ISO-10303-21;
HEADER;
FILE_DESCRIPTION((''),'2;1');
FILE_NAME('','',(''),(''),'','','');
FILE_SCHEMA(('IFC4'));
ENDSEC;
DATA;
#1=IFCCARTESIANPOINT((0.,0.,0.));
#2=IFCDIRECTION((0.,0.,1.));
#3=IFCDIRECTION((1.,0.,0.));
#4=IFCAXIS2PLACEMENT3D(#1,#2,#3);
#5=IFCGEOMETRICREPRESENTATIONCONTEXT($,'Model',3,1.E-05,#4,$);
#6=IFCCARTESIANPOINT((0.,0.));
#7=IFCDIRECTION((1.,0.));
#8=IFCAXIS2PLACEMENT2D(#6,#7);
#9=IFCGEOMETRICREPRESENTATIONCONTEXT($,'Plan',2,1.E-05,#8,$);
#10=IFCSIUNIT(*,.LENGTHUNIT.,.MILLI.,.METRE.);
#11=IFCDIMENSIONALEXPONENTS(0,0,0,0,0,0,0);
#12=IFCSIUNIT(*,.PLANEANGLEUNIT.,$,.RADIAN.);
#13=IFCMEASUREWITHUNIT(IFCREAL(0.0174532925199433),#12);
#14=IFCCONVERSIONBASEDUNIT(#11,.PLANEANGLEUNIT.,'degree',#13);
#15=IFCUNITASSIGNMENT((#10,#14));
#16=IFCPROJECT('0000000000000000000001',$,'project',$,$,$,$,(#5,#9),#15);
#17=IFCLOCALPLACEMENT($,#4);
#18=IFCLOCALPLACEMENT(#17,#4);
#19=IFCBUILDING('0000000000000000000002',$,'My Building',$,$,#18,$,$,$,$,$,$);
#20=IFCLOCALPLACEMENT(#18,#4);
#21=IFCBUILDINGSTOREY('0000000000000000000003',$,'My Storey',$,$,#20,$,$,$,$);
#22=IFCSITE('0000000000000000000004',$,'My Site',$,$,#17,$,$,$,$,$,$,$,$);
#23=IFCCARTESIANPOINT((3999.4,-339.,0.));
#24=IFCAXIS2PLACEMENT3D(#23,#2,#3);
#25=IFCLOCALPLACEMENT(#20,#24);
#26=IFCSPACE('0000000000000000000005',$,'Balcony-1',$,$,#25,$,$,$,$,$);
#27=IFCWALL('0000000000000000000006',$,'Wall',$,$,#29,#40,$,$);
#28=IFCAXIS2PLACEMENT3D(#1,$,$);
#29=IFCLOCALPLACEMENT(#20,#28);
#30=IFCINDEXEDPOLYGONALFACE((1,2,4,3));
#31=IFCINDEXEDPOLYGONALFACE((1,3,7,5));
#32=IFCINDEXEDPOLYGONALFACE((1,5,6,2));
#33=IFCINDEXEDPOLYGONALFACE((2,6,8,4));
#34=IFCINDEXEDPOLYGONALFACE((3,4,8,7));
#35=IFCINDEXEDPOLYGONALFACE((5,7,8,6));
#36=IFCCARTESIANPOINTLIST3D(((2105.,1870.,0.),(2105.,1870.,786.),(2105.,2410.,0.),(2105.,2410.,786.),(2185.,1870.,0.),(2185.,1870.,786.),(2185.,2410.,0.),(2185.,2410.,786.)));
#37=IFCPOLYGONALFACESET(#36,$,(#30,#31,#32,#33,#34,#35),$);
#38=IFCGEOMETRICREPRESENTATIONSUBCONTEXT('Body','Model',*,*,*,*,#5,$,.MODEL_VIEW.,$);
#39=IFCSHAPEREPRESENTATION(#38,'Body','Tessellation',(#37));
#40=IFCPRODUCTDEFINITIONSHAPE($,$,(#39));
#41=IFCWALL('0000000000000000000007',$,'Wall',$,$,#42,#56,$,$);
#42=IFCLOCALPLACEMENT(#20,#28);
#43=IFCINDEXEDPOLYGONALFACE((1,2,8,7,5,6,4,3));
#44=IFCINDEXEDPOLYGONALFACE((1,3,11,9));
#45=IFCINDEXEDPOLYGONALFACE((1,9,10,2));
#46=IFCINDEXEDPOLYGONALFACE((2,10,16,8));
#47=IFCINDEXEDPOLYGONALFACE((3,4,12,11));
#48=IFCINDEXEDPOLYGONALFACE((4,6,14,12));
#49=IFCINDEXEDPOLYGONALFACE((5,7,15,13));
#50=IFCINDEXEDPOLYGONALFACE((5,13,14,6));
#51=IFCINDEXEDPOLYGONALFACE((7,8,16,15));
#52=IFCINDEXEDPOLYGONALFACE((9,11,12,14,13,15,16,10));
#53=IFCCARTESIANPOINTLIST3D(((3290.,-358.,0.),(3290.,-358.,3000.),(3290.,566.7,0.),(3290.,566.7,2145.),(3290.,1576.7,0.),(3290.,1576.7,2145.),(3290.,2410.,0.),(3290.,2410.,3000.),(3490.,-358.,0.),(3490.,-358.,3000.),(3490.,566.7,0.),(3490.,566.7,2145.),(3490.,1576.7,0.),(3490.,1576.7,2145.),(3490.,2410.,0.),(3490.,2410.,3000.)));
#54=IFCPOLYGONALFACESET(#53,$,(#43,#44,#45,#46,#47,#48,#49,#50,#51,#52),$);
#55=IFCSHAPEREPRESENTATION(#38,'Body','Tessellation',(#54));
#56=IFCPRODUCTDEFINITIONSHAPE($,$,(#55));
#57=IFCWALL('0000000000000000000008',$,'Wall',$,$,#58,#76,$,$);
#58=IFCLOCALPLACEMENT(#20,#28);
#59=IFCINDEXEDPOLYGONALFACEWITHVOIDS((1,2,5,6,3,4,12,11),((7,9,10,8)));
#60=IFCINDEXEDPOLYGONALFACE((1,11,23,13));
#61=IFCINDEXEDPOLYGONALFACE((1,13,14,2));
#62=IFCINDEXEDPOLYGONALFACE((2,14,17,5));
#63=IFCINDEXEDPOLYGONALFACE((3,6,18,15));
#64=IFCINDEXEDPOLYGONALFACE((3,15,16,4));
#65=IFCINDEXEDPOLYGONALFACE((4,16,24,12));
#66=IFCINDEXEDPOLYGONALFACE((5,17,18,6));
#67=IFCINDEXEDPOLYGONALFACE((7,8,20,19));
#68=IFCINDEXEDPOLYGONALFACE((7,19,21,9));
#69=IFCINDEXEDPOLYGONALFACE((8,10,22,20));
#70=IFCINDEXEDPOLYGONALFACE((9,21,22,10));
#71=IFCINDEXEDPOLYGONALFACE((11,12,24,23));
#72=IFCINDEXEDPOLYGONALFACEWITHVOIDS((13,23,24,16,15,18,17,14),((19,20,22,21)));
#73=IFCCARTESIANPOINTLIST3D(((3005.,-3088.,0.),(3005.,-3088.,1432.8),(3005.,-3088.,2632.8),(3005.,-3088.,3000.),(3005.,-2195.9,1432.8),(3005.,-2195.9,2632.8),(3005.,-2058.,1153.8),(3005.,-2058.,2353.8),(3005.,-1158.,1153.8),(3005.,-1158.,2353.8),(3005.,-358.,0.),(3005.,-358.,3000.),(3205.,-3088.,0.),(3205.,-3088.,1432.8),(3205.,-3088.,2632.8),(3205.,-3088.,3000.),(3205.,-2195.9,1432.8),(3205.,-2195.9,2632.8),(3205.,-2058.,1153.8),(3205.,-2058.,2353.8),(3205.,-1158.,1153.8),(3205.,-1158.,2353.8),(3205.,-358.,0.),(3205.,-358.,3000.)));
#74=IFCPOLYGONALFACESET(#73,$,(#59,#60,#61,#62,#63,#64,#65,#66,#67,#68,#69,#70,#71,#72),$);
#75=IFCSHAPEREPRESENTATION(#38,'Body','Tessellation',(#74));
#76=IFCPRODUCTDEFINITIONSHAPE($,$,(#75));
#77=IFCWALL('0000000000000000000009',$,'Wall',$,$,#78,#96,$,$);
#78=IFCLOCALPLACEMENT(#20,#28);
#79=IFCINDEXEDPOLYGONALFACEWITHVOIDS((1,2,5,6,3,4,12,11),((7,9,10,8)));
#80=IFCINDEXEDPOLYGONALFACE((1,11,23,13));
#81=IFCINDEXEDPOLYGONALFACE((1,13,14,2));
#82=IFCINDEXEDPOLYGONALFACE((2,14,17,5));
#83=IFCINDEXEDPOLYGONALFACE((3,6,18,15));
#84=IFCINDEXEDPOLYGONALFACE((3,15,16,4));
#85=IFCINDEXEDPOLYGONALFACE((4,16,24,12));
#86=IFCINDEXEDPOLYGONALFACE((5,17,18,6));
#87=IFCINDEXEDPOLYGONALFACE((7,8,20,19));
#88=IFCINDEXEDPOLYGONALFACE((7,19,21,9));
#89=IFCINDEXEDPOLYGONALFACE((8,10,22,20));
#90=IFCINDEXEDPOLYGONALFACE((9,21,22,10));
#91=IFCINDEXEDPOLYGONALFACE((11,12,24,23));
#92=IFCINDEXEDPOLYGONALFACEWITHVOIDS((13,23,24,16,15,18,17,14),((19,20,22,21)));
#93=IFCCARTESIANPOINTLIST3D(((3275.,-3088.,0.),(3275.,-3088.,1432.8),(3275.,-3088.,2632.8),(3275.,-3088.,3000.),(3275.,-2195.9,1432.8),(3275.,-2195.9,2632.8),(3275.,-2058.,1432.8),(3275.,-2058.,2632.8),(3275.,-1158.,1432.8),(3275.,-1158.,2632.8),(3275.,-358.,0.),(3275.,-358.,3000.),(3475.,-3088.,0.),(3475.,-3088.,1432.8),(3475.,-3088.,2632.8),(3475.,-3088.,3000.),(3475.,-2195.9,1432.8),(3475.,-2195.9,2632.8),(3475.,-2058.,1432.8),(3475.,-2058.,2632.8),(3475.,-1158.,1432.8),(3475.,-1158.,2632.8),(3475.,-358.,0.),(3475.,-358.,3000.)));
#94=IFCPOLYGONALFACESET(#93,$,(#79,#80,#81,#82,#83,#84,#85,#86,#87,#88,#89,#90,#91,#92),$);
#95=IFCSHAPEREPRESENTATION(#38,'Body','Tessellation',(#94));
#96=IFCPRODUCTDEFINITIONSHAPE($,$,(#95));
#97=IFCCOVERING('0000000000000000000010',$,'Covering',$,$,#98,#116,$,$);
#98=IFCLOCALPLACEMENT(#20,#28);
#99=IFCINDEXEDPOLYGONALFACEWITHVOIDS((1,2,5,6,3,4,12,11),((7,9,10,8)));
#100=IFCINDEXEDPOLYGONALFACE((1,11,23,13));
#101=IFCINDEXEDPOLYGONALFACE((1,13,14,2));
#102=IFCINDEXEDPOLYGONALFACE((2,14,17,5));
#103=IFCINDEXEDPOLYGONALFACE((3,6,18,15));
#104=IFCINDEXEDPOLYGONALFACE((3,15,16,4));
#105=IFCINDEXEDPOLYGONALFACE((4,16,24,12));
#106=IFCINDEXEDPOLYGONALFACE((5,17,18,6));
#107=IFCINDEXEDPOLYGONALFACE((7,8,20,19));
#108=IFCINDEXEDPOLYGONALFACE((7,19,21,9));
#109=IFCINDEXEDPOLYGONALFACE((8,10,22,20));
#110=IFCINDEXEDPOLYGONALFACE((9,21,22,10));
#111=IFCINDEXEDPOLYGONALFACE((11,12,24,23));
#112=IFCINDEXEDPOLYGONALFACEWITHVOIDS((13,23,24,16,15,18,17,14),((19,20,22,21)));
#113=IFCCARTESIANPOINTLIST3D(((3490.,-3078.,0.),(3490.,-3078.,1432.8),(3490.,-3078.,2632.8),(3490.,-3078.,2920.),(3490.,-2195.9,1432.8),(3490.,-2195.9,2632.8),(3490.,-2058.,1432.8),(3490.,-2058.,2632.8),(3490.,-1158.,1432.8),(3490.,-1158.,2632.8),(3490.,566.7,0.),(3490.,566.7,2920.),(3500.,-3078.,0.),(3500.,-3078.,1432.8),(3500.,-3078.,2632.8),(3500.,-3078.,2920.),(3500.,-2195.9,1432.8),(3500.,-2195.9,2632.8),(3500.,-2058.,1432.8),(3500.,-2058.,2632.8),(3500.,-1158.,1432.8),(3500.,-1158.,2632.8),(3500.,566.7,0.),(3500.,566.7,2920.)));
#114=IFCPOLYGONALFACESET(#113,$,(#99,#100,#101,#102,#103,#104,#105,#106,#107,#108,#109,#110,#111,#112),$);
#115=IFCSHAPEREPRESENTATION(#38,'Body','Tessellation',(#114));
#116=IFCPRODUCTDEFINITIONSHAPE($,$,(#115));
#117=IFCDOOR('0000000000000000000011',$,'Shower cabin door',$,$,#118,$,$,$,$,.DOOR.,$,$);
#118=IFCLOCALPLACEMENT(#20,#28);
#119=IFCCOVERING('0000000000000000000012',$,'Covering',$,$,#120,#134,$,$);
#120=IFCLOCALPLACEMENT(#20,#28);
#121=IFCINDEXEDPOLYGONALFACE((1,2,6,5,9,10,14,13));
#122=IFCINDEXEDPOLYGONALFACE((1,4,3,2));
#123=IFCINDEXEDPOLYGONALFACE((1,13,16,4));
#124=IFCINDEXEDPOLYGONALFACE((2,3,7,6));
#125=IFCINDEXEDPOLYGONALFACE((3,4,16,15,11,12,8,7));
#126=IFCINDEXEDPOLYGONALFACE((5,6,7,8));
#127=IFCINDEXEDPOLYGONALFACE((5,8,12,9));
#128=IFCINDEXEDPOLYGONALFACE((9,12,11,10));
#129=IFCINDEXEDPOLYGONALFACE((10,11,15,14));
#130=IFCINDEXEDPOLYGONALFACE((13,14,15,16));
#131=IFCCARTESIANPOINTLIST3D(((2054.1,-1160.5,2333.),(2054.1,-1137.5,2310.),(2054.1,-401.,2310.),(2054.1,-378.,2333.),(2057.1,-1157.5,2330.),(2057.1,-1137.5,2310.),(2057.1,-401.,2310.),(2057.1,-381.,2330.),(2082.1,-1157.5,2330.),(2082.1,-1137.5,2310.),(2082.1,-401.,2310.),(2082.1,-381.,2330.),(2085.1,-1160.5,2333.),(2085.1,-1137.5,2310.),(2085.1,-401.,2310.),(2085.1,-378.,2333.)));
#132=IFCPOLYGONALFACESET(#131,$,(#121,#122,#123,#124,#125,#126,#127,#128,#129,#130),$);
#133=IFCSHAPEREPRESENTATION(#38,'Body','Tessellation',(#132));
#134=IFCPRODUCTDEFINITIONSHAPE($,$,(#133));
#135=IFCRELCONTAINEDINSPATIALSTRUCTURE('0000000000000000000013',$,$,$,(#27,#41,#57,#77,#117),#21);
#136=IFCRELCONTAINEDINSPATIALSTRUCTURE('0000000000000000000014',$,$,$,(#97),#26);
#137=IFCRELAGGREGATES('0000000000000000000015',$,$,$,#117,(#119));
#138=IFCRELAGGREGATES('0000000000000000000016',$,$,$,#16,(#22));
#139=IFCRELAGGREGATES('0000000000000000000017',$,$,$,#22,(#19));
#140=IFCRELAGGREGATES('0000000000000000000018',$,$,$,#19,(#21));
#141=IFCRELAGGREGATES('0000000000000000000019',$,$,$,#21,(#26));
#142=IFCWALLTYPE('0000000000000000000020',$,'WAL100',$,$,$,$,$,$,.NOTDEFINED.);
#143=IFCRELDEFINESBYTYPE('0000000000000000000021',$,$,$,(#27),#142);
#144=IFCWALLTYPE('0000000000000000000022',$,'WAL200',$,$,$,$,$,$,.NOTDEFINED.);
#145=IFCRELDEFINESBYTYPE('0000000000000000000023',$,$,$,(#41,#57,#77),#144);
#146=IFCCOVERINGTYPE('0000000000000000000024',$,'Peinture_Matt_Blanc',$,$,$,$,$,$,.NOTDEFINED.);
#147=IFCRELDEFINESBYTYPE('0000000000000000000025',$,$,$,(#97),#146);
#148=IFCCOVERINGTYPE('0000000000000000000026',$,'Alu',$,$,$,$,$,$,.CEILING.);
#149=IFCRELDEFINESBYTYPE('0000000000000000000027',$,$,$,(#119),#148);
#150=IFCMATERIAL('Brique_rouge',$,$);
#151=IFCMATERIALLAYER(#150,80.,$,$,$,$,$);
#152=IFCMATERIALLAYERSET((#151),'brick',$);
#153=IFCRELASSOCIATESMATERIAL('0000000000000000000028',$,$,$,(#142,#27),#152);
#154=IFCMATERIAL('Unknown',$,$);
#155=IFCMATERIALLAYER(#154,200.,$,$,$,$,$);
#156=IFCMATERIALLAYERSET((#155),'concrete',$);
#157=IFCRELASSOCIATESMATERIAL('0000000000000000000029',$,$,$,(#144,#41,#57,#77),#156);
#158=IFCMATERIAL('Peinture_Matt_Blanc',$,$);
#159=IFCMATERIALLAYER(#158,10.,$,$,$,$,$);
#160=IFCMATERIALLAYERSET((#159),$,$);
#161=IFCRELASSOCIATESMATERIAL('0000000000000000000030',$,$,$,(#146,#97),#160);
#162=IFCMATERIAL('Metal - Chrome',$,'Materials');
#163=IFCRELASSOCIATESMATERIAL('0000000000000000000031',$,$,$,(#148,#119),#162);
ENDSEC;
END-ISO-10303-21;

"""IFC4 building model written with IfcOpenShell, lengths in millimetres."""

from ifc_helpers import new_model, entity, si_unit, converted_unit, frame, origin_with_axes, origin_2d_with_axis, place, context, subcontext, project, spatial, line, indexed_curve, outline, extrude, clip, halfspace, source, transform, mapped, material, layer, layer_set, layer_usage, material_profile, profile_set, profile_usage, type_object, element, aggregate, save


model = new_model("IFC4")

# Units and contexts
model_context = context("Model", 3, precision=1e-05, world=origin_with_axes())
plan_context = context("Plan", 2, precision=1e-05, world=origin_2d_with_axis())
body_context_1 = subcontext(model_context, "Body", "Model", "MODEL_VIEW")
ifc_project = project(units=[si_unit("LENGTHUNIT", "METRE", prefix="MILLI"), converted_unit("PLANEANGLEUNIT", "degree", entity("IfcReal", 0.0174532925199433), si_unit("PLANEANGLEUNIT", "RADIAN"), dimensions=[0, 0, 0, 0, 0, 0, 0])], contexts=[model_context, plan_context])

# Site, building, storey
site_placement = place(None, origin_with_axes())
site = spatial("IfcSite", under=ifc_project, at=site_placement, Name="My Site")
building_placement = place(site_placement, origin_with_axes())
building = spatial("IfcBuilding", under=site, at=building_placement, Name="My Building")
storey_placement = place(building_placement, origin_with_axes())
storey = spatial("IfcBuildingStorey", under=building, at=storey_placement, Name="My Storey")

# Wall
ifc_material_1 = material(Name="Brique_rouge")
ifc_layer_1 = layer(ifc_material_1, 80.0)
ifc_layer_set_1 = layer_set([ifc_layer_1], Name="brick")
ifc_layer_usage_1 = layer_usage(ifc_layer_set_1, "AXIS2", "POSITIVE", 0.0)
wall_type_1 = type_object("IfcWallType", Name="WAL100", PredefinedType="NOTDEFINED", material=ifc_layer_set_1)
wall_1_placement = place(storey_placement, frame((2185.0, 1870.0, 0.0), z_axis=(0.0, 0.0, 1.0), x_axis=(0.000001, 1.0, 0.0)))
element("IfcWall", 1, at=wall_1_placement, inside=storey, type_object=wall_type_1, material=ifc_layer_usage_1, Name="Wall", context=body_context_1, shape_type="Clipping", body=[
    clip(extrude(outline(indexed_curve([(0.0, 0.0), (0.0, 80.0), (540.0, 80.0), (540.0, 0.0), (0.0, 0.0)], self_intersect=False)), origin_with_axes(), (0.0, 0.0, 1.0), 786.0), halfspace(frame((0.0, 0.0, 786.0), z_axis=(0.0, 0.0, 1.0), x_axis=(-1.0, 0.0, 0.0)), False)),
])

# Wall, opening
ifc_material_2 = material(Name="Unknown")
ifc_layer_2 = layer(ifc_material_2, 200.0)
ifc_layer_set_2 = layer_set([ifc_layer_2], Name="concrete")
ifc_layer_usage_2 = layer_usage(ifc_layer_set_2, "AXIS2", "POSITIVE", 0.0)
wall_type_2 = type_object("IfcWallType", Name="WAL200", PredefinedType="NOTDEFINED", material=ifc_layer_set_2)
wall_2_placement = place(storey_placement, frame((3490.0, -358.0, 0.0), z_axis=(0.0, 0.0, 1.0), x_axis=(0.0, 1.0, 0.0)))
wall_2 = element("IfcWall", 2, at=wall_2_placement, inside=storey, type_object=wall_type_2, material=ifc_layer_usage_2, Name="Wall", context=body_context_1, shape_type="SweptSolid", body=[
    extrude(outline(indexed_curve([(0.0, 0.0), (0.0, 200.0), (2768.0, 200.0), (2768.0, 0.0), (0.0, 0.0)], self_intersect=False)), origin_with_axes(), (0.0, 0.0, 1.0), 3000.0),
])
shared_shape_1 = source(origin_with_axes(), body_context_1, "Body", "SweptSolid", [
    extrude(outline(indexed_curve([(0.0, 0.0), (1010.0, 0.0), (1010.0, 2145.0), (0.0, 2145.0)], segments=[line(1, 2, 3, 4, 1)])), frame((0.0, -600.0, 0.0), z_axis=(0.0, -1.0, 0.0), x_axis=(1.0, 0.0, 0.0)), (0.0, 0.0, -1.0), 1200.0),
])
opening_1_placement = place(wall_2_placement, frame((924.7, 0.0, 0.0), z_axis=(0.0, 0.0, 1.0), x_axis=(1.0, 0.0, 0.0)))
element("IfcOpeningElement", 3, at=opening_1_placement, cuts=wall_2, PredefinedType="OPENING", context=body_context_1, shape_type="MappedRepresentation", body=[
    mapped(shared_shape_1, transform((0.0, 0.0, 0.0), x_axis=(1.0, 0.0, 0.0), y_axis=(0.0, 1.0, 0.0), z_axis=(0.0, 0.0, 1.0), scale=1.0)),
])

# Walls, openings
ifc_layer_usage_3 = layer_usage(ifc_layer_set_2, "AXIS2", "POSITIVE", 0.0)
wall_3_placement = place(storey_placement, frame((3005.0, -358.0, 0.0), z_axis=(0.0, 0.0, 1.0), x_axis=(-0.000001, -1.0, 0.0)))
wall_3 = element("IfcWall", 4, at=wall_3_placement, inside=storey, type_object=wall_type_2, material=ifc_layer_usage_3, Name="Wall", context=body_context_1, shape_type="SweptSolid", body=[
    extrude(outline(indexed_curve([(0.0, 0.0), (0.0, 200.0), (2730.0, 200.0), (2730.0, 0.0), (0.0, 0.0)], self_intersect=False)), origin_with_axes(), (0.0, 0.0, 1.0), 3000.0),
])
shared_shape_2 = source(origin_with_axes(), body_context_1, "Body", "SweptSolid", [
    extrude(outline(indexed_curve([(0.0, 0.0), (900.0, 0.0), (900.0, 1200.0), (0.0, 1200.0)], segments=[line(1, 2, 3, 4, 1)])), frame((0.0, -600.0, 0.0), z_axis=(0.0, -1.0, 0.0), x_axis=(1.0, 0.0, 0.0)), (0.0, 0.0, -1.0), 1200.0),
])
opening_2_placement = place(wall_3_placement, frame((1837.9, 0.0, 1432.8), z_axis=(0.0, 0.0, 1.0), x_axis=(1.0, 0.0, 0.0)))
element("IfcOpeningElement", 5, at=opening_2_placement, cuts=wall_3, PredefinedType="OPENING", context=body_context_1, shape_type="MappedRepresentation", body=[
    mapped(shared_shape_2, transform((0.0, 0.0, 0.0), x_axis=(1.0, 0.0, 0.0), y_axis=(0.0, 1.0, 0.0), z_axis=(0.0, 0.0, 1.0), scale=1.0)),
])
shared_shape_3 = source(origin_with_axes(), body_context_1, "Body", "SolidModel", [
    extrude(outline(indexed_curve([(0.0, 920.9), (900.0, 920.9), (900.0, -279.1), (0.0, -279.1), (0.0, 920.9)])), frame((0.0, -600.0, 0.0), z_axis=(0.0, -1.0, 0.0), x_axis=(1.0, 0.0, 0.0)), (0.0, 0.0, -1.0), 1200.0),
])
opening_3_placement = place(wall_3_placement, frame((800.0, 0.0, 1432.8), z_axis=(0.0, 0.0, 1.0), x_axis=(1.0, 0.0, 0.0)))
element("IfcOpeningElement", 6, at=opening_3_placement, cuts=wall_3, PredefinedType="OPENING", context=body_context_1, shape_type="MappedRepresentation", body=[
    mapped(shared_shape_3, transform((0.0, 0.0, 0.0), x_axis=(1.0, 0.0, 0.0), y_axis=(0.0, 1.0, 0.0), z_axis=(0.0, 0.0, 1.0), scale=1.0)),
])
ifc_layer_usage_4 = layer_usage(ifc_layer_set_2, "AXIS2", "POSITIVE", 0.0)
wall_4_placement = place(storey_placement, frame((3275.0, -358.0, 0.0), z_axis=(0.0, 0.0, 1.0), x_axis=(-0.000001, -1.0, 0.0)))
wall_4 = element("IfcWall", 7, at=wall_4_placement, inside=storey, type_object=wall_type_2, material=ifc_layer_usage_4, Name="Wall", context=body_context_1, shape_type="SweptSolid", body=[
    extrude(outline(indexed_curve([(0.0, 0.0), (0.0, 200.0), (2730.0, 200.0), (2730.0, 0.0), (0.0, 0.0)], self_intersect=False)), origin_with_axes(), (0.0, 0.0, 1.0), 3000.0),
])
shared_shape_4 = source(origin_with_axes(), body_context_1, "Body", "SweptSolid", [
    extrude(outline(indexed_curve([(0.0, 0.0), (900.0, 0.0), (900.0, 1200.0), (0.0, 1200.0)], segments=[line(1, 2, 3, 4, 1)])), frame((0.0, -600.0, 0.0), z_axis=(0.0, -1.0, 0.0), x_axis=(1.0, 0.0, 0.0)), (0.0, 0.0, -1.0), 1200.0),
])
opening_4_placement = place(wall_4_placement, frame((800.0, -285.0, 1432.8), z_axis=(0.0, 0.0, 1.0), x_axis=(1.0, 0.0, 0.0)))
element("IfcOpeningElement", 8, at=opening_4_placement, cuts=wall_4, PredefinedType="OPENING", context=body_context_1, shape_type="MappedRepresentation", body=[
    mapped(shared_shape_4, transform((0.0, 0.0, 0.0), x_axis=(1.0, 0.0, 0.0), y_axis=(0.0, 1.0, 0.0), z_axis=(0.0, 0.0, 1.0), scale=1.0)),
])
shared_shape_5 = source(origin_with_axes(), body_context_1, "Body", "SweptSolid", [
    extrude(outline(indexed_curve([(0.0, 0.0), (900.0, 0.0), (900.0, 1200.0), (0.0, 1200.0)], segments=[line(1, 2, 3, 4, 1)])), frame((0.0, -600.0, 0.0), z_axis=(0.0, -1.0, 0.0), x_axis=(1.0, 0.0, 0.0)), (0.0, 0.0, -1.0), 1200.0),
])
opening_5_placement = place(wall_4_placement, frame((1837.9, -285.0, 1432.8), z_axis=(0.0, 0.0, 1.0), x_axis=(1.0, 0.0, 0.0)))
element("IfcOpeningElement", 9, at=opening_5_placement, cuts=wall_4, PredefinedType="OPENING", context=body_context_1, shape_type="MappedRepresentation", body=[
    mapped(shared_shape_5, transform((0.0, 0.0, 0.0), x_axis=(1.0, 0.0, 0.0), y_axis=(0.0, 1.0, 0.0), z_axis=(0.0, 0.0, 1.0), scale=1.0)),
])

# Shared definitions
ifc_material_3 = material(Name="Peinture_Matt_Blanc")
ifc_layer_3 = layer(ifc_material_3, 10.0)
ifc_layer_set_3 = layer_set([ifc_layer_3])
covering_type_1 = type_object("IfcCoveringType", Name="Peinture_Matt_Blanc", PredefinedType="NOTDEFINED", material=ifc_layer_set_3)

# Shared definitions
space_1_placement = place(storey_placement, frame((3999.4, -339.0, 0.0), z_axis=(0.0, 0.0, 1.0), x_axis=(1.0, 0.0, 0.0)))
space_1 = spatial("IfcSpace", under=storey, at=space_1_placement, Name="Balcony-1")

# Covering, openings
ifc_layer_usage_5 = layer_usage(ifc_layer_set_3, "AXIS2", "POSITIVE", 0.0)
covering_1_placement = place(space_1_placement, frame((-509.4, 905.7, 0.0), z_axis=(0.0, 0.0, 1.0), x_axis=(-0.000003, -1.0, 0.0)))
covering_1 = element("IfcCovering", 10, at=covering_1_placement, inside=space_1, type_object=covering_type_1, material=ifc_layer_usage_5, Name="Covering", context=body_context_1, shape_type="Clipping", body=[
    clip(clip(extrude(outline(indexed_curve([(0.0, 0.0), (0.0, 10.0), (3644.7, 10.0), (3644.7, 0.0), (0.0, 0.0)], self_intersect=False)), origin_with_axes(), (0.0, 0.0, 1.0), 2920.0), halfspace(frame((0.0, 0.0, 2920.0), z_axis=(0.0, 0.0, 1.0), x_axis=(-1.0, 0.0, 0.0)), False)), halfspace(frame((0.0, 0.0, 2920.0), z_axis=(0.0, 0.0, 1.0), x_axis=(-1.0, 0.0, 0.0)), False)),
])
shared_shape_6 = source(origin_with_axes(), body_context_1, "Body", "SweptSolid", [
    extrude(outline(indexed_curve([(0.0, 0.0), (900.0, 0.0), (900.0, 1200.0), (0.0, 1200.0)], segments=[line(1, 2, 3, 4, 1)])), frame((0.0, -600.0, 0.0), z_axis=(0.0, -1.0, 0.0), x_axis=(1.0, 0.0, 0.0)), (0.0, 0.0, -1.0), 1200.0),
])
opening_6_placement = place(covering_1_placement, frame((2762.6, -485.0, 1432.8), z_axis=(0.0, 0.0, 1.0), x_axis=(1.0, 0.000002, 0.0)))
element("IfcOpeningElement", 11, at=opening_6_placement, cuts=covering_1, PredefinedType="OPENING", context=body_context_1, shape_type="MappedRepresentation", body=[
    mapped(shared_shape_6, transform((0.0, 0.0, 0.0), x_axis=(1.0, 0.0, 0.0), y_axis=(0.0, 1.0, 0.0), z_axis=(0.0, 0.0, 1.0), scale=1.0)),
])
shared_shape_7 = source(origin_with_axes(), body_context_1, "Body", "SweptSolid", [
    extrude(outline(indexed_curve([(0.0, 0.0), (900.0, 0.0), (900.0, 1200.0), (0.0, 1200.0)], segments=[line(1, 2, 3, 4, 1)])), frame((0.0, -600.0, 0.0), z_axis=(0.0, -1.0, 0.0), x_axis=(1.0, 0.0, 0.0)), (0.0, 0.0, -1.0), 1200.0),
])
opening_7_placement = place(covering_1_placement, frame((1724.7, -485.0, 1432.8), z_axis=(0.0, 0.0, 1.0), x_axis=(1.0, 0.000002, 0.0)))
element("IfcOpeningElement", 12, at=opening_7_placement, cuts=covering_1, PredefinedType="OPENING", context=body_context_1, shape_type="MappedRepresentation", body=[
    mapped(shared_shape_7, transform((0.0, 0.0, 0.0), x_axis=(1.0, 0.0, 0.0), y_axis=(0.0, 1.0, 0.0), z_axis=(0.0, 0.0, 1.0), scale=1.0)),
])

# Door, covering
door_placement = place(storey_placement, frame((2054.1, -378.0, 320.0), z_axis=(0.0, 0.0, 1.0), x_axis=(1.0, 0.0, 0.0)))
door = element("IfcDoor", 13, at=door_placement, inside=storey, Name="Shower cabin door", PredefinedType="DOOR")
ifc_material_4 = material(Name="Metal - Chrome", Category="Materials")
ifc_material_profile = material_profile(ifc_material_4, outline(indexed_curve([(0.0, 0.0), (0.0, 23.0), (3.0, 23.0), (3.0, 3.0), (28.0, 3.0), (28.0, 23.0), (31.0, 23.0), (31.0, 0.0)], segments=[line(1, 8), line(8, 7), line(7, 6), line(6, 5), line(5, 4), line(4, 3), line(3, 2), line(2, 1)], self_intersect=False)))
ifc_profile_set = profile_set([ifc_material_profile])
ifc_profile_usage = profile_usage(ifc_profile_set, cardinal=5)
covering_type_2 = type_object("IfcCoveringType", Name="Alu", PredefinedType="CEILING", material=ifc_profile_set)
covering_2_placement = place(door_placement, frame((31.0, 0.0, 2013.0), z_axis=(0.0, -1.0, 0.0), x_axis=(-1.0, 0.0, 0.0)))
covering_2 = element("IfcCovering", 14, at=covering_2_placement, type_object=covering_type_2, material=ifc_profile_usage, Name="Covering", context=body_context_1, shape_type="Clipping", body=[
    clip(clip(extrude(outline(indexed_curve([(0.0, 0.0), (0.0, 23.0), (3.0, 23.0), (3.0, 3.0), (28.0, 3.0), (28.0, 23.0), (31.0, 23.0), (31.0, 0.0)], segments=[line(1, 8), line(8, 7), line(7, 6), line(6, 5), line(5, 4), line(4, 3), line(3, 2), line(2, 1)], self_intersect=False)), origin_with_axes(), (0.0, 0.0, 1.0), 782.5), halfspace(frame((2085.1, 0.0, 0.0), z_axis=(0.0, 0.707107, -0.707107), x_axis=(1.0, 0.0, 0.0)), False)), halfspace(frame((2085.1, 0.0, 782.5), z_axis=(0.0, 0.707107, 0.707107), x_axis=(1.0, 0.0, 0.0)), False)),
])
aggregate(door, [covering_2])

save(model, "model.ifc")
